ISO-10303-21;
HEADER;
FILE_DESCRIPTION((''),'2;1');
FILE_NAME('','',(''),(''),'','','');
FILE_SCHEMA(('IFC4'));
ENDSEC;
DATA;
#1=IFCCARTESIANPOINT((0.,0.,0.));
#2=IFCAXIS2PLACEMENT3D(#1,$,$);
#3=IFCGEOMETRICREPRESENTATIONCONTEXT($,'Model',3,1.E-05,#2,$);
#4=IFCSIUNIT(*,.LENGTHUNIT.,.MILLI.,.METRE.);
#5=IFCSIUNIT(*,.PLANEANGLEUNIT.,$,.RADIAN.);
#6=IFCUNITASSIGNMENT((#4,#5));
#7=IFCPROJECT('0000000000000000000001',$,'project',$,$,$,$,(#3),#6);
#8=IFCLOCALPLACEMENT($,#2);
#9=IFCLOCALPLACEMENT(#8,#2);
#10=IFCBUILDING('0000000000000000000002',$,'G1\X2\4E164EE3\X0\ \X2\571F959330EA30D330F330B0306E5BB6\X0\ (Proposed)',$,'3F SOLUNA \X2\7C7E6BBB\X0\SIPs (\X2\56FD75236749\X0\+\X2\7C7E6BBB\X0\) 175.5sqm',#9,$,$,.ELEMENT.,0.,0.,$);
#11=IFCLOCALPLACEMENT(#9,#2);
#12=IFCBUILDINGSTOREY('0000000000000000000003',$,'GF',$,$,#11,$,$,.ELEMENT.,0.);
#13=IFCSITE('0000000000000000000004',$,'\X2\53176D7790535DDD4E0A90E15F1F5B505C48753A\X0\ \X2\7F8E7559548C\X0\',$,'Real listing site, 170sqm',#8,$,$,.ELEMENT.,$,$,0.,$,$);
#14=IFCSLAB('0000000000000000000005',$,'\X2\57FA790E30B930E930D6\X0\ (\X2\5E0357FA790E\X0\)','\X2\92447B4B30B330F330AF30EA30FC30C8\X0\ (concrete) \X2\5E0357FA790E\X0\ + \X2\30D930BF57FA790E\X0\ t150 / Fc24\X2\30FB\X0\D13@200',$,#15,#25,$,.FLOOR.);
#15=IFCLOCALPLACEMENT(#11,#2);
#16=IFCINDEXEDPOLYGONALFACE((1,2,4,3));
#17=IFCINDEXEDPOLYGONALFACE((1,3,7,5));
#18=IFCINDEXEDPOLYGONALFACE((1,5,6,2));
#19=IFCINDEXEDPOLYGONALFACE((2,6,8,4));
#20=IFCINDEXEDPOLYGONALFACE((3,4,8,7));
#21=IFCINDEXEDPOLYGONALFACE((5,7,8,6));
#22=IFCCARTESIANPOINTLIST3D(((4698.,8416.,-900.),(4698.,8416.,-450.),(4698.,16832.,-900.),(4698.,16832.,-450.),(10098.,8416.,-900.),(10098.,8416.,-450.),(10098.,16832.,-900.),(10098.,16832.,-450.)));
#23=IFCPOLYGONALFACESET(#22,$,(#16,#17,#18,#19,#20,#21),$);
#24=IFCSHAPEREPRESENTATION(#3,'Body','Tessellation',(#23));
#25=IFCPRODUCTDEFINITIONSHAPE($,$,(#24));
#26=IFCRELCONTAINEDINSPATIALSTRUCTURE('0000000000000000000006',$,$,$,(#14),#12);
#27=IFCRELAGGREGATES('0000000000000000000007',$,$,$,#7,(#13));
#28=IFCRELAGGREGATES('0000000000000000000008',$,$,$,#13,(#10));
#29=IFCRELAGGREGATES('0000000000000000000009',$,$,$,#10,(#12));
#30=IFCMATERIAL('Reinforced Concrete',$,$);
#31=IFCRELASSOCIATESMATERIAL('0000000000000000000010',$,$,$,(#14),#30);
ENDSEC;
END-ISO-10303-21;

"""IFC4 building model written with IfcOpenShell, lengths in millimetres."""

from ifc_helpers import new_model, si_unit, frame, frame_2d, origin, place, context, project, spatial, rectangle, extrude, material, element, save


model = new_model("IFC4")

# Units and contexts
model_context = context("Model", 3, precision=1e-05, world=origin())
ifc_project = project(units=[si_unit("LENGTHUNIT", "METRE", prefix="MILLI"), si_unit("PLANEANGLEUNIT", "RADIAN")], contexts=[model_context])

# Site, building, storey
site_placement = place(None, origin())
site = spatial("IfcSite", under=ifc_project, at=site_placement, Name="北海道川上郡弟子屈町 美留和", ObjectType="Real listing site, 170sqm", CompositionType="ELEMENT", RefElevation=0.0)
building_placement = place(site_placement, origin())
building = spatial("IfcBuilding", under=site, at=building_placement, Name="G1世代 土間リビングの家 (Proposed)", ObjectType="3F SOLUNA 籾殻SIPs (国産杉+籾殻) 175.5sqm", CompositionType="ELEMENT", ElevationOfRefHeight=0.0, ElevationOfTerrain=0.0)
storey_placement = place(building_placement, origin())
storey = spatial("IfcBuildingStorey", under=building, at=storey_placement, Name="GF", CompositionType="ELEMENT", Elevation=0.0)

# Slab
ifc_material_1 = material(Name="Reinforced Concrete")
slab_1_placement = place(storey_placement, frame((2349.0, 4208.0, -450.0)))
element("IfcSlab", 1, at=slab_1_placement, inside=storey, material=ifc_material_1, Name="基礎スラブ (布基礎)", Description="鉄筋コンクリート (concrete) 布基礎 + ベタ基礎 t150 / Fc24・D13@200", PredefinedType="FLOOR", context=model_context, shape_type="SweptSolid", body=[
    extrude(rectangle(XDim=5400.0, YDim=8416.0, at=frame_2d((2700.0, 4208.0))), frame((2349.0, 4208.0, -450.0)), (0.0, 0.0, 1.0), 450.0),
])

save(model, "model.ifc")
